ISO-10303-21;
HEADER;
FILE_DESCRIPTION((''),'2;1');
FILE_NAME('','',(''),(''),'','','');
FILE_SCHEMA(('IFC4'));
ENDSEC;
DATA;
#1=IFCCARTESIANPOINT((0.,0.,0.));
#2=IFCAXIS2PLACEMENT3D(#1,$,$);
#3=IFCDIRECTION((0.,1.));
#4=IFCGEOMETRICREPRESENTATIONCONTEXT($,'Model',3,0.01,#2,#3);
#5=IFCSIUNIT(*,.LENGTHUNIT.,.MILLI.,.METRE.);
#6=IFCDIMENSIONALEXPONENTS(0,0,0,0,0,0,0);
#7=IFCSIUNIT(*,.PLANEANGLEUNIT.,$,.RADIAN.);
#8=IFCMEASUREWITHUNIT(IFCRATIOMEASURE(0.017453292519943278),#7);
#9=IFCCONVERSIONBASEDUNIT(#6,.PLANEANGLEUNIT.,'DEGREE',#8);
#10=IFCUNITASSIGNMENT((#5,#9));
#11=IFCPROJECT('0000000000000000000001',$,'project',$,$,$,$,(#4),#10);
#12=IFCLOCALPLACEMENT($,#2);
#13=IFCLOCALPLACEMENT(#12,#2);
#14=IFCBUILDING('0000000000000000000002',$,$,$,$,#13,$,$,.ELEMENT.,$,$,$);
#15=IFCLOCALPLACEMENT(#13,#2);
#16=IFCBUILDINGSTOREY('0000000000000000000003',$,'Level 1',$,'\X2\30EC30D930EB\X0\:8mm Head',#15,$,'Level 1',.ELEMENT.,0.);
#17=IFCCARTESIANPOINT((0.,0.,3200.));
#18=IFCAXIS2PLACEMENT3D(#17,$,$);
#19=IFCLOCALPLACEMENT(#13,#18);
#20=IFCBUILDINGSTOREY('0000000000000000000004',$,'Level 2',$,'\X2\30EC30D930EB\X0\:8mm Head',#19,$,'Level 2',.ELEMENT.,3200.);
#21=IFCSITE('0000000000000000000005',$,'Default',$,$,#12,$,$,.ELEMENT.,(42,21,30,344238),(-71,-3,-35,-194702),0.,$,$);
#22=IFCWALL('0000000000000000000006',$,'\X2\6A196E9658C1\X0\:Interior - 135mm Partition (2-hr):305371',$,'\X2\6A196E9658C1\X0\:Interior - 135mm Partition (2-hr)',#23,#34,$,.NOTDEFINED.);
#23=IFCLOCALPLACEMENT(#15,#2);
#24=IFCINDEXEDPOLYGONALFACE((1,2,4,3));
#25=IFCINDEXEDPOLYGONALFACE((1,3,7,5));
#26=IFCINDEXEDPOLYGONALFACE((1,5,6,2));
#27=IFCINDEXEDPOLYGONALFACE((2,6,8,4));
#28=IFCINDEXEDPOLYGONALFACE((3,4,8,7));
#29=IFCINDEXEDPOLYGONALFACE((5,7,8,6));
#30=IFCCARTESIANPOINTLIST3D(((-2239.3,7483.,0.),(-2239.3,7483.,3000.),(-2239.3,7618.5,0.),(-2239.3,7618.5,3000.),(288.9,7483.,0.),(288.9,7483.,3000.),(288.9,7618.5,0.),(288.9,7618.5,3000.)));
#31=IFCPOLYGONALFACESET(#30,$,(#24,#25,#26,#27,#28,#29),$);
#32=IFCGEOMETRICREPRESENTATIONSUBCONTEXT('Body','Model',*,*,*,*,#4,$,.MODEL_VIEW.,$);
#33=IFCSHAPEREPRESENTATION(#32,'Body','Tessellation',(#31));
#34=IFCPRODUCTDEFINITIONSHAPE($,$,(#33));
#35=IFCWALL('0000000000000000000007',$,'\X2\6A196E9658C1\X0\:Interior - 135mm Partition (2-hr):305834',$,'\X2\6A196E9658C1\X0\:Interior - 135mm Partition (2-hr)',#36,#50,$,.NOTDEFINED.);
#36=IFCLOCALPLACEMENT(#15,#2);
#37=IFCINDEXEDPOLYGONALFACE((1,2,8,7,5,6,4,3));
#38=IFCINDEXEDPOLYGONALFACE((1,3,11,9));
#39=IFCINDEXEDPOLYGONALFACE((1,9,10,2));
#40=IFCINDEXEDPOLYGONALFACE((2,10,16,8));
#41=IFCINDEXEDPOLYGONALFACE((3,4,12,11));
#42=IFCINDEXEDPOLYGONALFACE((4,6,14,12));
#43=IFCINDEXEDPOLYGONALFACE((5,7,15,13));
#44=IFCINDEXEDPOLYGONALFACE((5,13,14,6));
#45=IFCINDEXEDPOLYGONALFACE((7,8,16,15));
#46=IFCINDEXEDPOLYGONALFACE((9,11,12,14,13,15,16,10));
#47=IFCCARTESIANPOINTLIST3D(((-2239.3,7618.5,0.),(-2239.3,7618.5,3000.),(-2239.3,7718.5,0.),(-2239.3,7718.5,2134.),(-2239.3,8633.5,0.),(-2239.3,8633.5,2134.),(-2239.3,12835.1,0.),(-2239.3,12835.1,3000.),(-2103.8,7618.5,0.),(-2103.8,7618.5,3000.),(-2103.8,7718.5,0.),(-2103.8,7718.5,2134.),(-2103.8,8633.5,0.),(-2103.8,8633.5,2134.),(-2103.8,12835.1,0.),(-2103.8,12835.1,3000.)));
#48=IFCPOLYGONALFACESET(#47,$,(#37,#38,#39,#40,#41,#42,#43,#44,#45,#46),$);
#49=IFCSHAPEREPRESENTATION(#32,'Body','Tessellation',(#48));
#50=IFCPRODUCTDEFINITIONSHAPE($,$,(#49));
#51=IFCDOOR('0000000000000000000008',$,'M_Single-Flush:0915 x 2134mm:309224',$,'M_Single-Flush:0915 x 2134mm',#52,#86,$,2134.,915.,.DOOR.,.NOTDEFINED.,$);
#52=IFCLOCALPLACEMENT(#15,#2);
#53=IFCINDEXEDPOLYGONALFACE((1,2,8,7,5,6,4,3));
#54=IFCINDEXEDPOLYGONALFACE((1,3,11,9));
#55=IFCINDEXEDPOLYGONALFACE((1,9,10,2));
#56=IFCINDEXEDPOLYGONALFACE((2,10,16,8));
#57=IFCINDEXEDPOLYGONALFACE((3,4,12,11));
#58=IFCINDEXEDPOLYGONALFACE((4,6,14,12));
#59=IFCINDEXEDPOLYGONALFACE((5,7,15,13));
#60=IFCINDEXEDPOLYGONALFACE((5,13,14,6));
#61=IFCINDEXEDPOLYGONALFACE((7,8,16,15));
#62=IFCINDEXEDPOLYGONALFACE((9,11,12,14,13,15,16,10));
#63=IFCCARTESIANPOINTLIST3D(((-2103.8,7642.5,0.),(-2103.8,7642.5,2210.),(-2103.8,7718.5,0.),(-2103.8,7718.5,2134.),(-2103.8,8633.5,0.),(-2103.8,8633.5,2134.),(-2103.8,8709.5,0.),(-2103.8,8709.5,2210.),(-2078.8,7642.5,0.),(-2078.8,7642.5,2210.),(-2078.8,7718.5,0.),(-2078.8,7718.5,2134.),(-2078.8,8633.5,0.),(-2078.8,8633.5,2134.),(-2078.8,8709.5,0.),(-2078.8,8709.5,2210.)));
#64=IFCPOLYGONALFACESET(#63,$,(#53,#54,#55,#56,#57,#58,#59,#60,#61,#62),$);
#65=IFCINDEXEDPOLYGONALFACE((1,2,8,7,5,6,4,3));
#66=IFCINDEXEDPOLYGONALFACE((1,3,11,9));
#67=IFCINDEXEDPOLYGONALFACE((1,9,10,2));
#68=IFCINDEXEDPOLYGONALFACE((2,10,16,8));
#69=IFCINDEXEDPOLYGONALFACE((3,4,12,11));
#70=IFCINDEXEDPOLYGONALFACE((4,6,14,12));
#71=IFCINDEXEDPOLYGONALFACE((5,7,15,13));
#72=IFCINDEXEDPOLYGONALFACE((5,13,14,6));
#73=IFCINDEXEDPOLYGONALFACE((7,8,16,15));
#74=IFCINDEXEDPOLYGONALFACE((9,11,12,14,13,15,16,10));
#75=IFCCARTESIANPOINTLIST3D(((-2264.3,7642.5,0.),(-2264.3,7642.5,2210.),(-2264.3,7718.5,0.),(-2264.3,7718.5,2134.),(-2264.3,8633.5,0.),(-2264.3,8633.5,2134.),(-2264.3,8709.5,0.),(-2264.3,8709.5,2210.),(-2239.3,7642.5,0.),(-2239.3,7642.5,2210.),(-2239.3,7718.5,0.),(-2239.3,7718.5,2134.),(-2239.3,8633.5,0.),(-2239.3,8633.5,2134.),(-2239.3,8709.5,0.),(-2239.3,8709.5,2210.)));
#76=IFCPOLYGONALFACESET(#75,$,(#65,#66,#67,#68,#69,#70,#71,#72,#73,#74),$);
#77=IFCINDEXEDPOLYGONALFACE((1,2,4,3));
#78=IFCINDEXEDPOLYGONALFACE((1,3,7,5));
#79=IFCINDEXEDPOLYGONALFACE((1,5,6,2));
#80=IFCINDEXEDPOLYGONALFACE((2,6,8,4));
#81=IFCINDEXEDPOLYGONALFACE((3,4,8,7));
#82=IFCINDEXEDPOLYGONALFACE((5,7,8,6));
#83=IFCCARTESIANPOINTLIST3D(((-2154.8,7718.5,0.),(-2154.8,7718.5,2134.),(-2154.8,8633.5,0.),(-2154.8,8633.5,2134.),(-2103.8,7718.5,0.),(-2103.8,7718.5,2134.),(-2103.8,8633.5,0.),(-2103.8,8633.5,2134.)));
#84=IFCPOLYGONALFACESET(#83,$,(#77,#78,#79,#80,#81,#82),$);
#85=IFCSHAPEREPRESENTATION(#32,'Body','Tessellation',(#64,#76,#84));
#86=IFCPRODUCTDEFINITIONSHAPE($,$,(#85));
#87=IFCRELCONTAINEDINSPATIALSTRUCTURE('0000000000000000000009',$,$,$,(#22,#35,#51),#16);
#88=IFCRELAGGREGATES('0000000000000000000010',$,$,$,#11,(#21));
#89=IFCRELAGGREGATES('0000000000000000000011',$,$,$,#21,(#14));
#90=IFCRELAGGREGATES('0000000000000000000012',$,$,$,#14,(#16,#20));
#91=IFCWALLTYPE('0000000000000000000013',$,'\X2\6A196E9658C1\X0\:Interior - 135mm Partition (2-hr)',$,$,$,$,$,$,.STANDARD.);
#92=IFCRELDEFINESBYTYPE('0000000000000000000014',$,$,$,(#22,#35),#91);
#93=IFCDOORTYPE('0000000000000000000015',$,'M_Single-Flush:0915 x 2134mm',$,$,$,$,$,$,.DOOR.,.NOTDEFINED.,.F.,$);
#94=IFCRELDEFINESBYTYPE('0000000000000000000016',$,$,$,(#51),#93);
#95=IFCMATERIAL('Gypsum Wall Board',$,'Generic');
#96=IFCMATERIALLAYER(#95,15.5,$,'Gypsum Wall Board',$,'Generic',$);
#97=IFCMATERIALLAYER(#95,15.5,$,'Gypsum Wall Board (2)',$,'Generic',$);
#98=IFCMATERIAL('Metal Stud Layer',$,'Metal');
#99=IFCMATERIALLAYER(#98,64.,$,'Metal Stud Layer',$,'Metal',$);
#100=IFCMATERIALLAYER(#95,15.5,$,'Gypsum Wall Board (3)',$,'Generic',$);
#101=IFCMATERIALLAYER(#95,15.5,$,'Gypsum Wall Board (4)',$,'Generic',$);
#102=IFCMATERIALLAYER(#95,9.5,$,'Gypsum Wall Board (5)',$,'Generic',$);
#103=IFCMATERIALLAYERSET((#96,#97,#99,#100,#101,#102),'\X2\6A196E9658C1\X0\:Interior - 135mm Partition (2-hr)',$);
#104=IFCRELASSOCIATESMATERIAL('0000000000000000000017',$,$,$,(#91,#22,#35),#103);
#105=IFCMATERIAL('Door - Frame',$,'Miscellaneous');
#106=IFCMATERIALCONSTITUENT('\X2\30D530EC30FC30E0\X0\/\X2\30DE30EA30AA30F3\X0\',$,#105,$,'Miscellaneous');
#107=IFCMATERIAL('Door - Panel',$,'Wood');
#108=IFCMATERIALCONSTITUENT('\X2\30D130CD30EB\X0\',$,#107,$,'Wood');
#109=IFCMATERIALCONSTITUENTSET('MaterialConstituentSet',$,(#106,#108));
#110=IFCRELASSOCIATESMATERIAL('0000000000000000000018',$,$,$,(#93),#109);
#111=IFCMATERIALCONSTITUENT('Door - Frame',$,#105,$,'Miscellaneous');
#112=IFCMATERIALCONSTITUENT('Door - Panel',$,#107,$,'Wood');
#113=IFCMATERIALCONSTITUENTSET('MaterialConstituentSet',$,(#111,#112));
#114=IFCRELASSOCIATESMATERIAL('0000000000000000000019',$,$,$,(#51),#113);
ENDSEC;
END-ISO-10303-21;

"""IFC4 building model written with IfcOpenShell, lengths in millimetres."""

from ifc_helpers import new_model, entity, si_unit, converted_unit, direction, frame, frame_2d, origin, place, context, subcontext, project, spatial, polyline, rectangle, outline, extrude, clip, bounded_halfspace, source, transform, mapped, material, layer, layer_set, layer_usage, constituent, constituent_set, type_object, type_shapes, element, fill, save


model = new_model("IFC4")

# Units and contexts
model_context = context("Model", 3, precision=0.01, world=origin(), true_north=direction((0.0, 1.0)))
body_context = subcontext(model_context, "Body", "Model", "MODEL_VIEW")
ifc_project = project(units=[si_unit("LENGTHUNIT", "METRE", prefix="MILLI"), converted_unit("PLANEANGLEUNIT", "DEGREE", entity("IfcRatioMeasure", 0.017453292519943278), si_unit("PLANEANGLEUNIT", "RADIAN"), dimensions=[0, 0, 0, 0, 0, 0, 0])], contexts=[model_context])

# Site, building, storey
site_placement = place(None, origin())
site = spatial("IfcSite", under=ifc_project, at=site_placement, Name="Default", CompositionType="ELEMENT", RefLatitude=(42, 21, 30, 344238), RefLongitude=(-71, -3, -35, -194702), RefElevation=0.0)
building_placement = place(site_placement, origin())
building = spatial("IfcBuilding", under=site, at=building_placement, CompositionType="ELEMENT")
storey_1_placement = place(building_placement, origin())
storey_1 = spatial("IfcBuildingStorey", under=building, at=storey_1_placement, Name="Level 1", ObjectType="レベル:8mm Head", LongName="Level 1", CompositionType="ELEMENT", Elevation=0.0)

# Shared definitions
storey_2_placement = place(building_placement, frame((0.0, 0.0, 3200.0)))
storey_2 = spatial("IfcBuildingStorey", under=building, at=storey_2_placement, Name="Level 2", ObjectType="レベル:8mm Head", LongName="Level 2", CompositionType="ELEMENT", Elevation=3200.0)

# Wall
ifc_material_1 = material(Name="Gypsum Wall Board", Category="Generic")
ifc_layer_1 = layer(ifc_material_1, 15.5, Name="Gypsum Wall Board", Category="Generic")
ifc_layer_2 = layer(ifc_material_1, 15.5, Name="Gypsum Wall Board (2)", Category="Generic")
ifc_material_2 = material(Name="Metal Stud Layer", Category="Metal")
ifc_layer_3 = layer(ifc_material_2, 64.0, Name="Metal Stud Layer", Category="Metal")
ifc_layer_4 = layer(ifc_material_1, 15.5, Name="Gypsum Wall Board (3)", Category="Generic")
ifc_layer_5 = layer(ifc_material_1, 15.5, Name="Gypsum Wall Board (4)", Category="Generic")
ifc_layer_6 = layer(ifc_material_1, 9.5, Name="Gypsum Wall Board (5)", Category="Generic")
ifc_layer_set_1 = layer_set([ifc_layer_1, ifc_layer_2, ifc_layer_3, ifc_layer_4, ifc_layer_5, ifc_layer_6], Name="標準壁:Interior - 135mm Partition (2-hr)")
ifc_layer_usage_1 = layer_usage(ifc_layer_set_1, "AXIS2", "NEGATIVE", 67.8)
wall_type_1 = type_object("IfcWallType", Name="標準壁:Interior - 135mm Partition (2-hr)", PredefinedType="STANDARD", material=ifc_layer_set_1)
wall_1_placement = place(storey_1_placement, frame((288.9, 7550.8, 0.0), z_axis=(0.0, 0.0, 1.0), x_axis=(-1.0, 0.0, 0.0)))
element("IfcWall", 1, at=wall_1_placement, inside=storey_1, type_object=wall_type_1, material=ifc_layer_usage_1, Name="標準壁:Interior - 135mm Partition (2-hr):305371", ObjectType="標準壁:Interior - 135mm Partition (2-hr)", PredefinedType="NOTDEFINED", context=body_context, shape_type="Clipping", body=[
    clip(extrude(rectangle(XDim=2528.2, YDim=135.5, at=frame_2d((1264.1, 0.0), x_axis=(-1.0, 0.0))), origin(), (0.0, 0.0, 1.0), 3000.0), bounded_halfspace(frame((0.0, -67.7, 3000.0), z_axis=(0.0, 0.0, -1.0), x_axis=(-1.0, 0.0, 0.0)), True, frame((0.0, -67.7, 3000.0)), polyline([(0.0, 0.0), (2392.7, 0.0), (2528.2, 0.0), (2528.2, 135.5), (0.0, 135.5), (0.0, 0.0)]))),
])

# Wall, opening, door
ifc_layer_usage_2 = layer_usage(ifc_layer_set_1, "AXIS2", "NEGATIVE", 67.8)
wall_2_placement = place(storey_1_placement, frame((-2171.5, 12835.1, 0.0), z_axis=(0.0, 0.0, 1.0), x_axis=(0.0, -1.0, 0.0)))
wall_2 = element("IfcWall", 2, at=wall_2_placement, inside=storey_1, type_object=wall_type_1, material=ifc_layer_usage_2, Name="標準壁:Interior - 135mm Partition (2-hr):305834", ObjectType="標準壁:Interior - 135mm Partition (2-hr)", PredefinedType="NOTDEFINED", context=body_context, shape_type="Clipping", body=[
    clip(extrude(rectangle(XDim=5216.6, YDim=135.5, at=frame_2d((2608.3, 0.0), x_axis=(-1.0, 0.0))), origin(), (0.0, 0.0, 1.0), 3000.0), bounded_halfspace(frame((0.0, -67.8, 3000.0), z_axis=(0.0, 0.0, -1.0), x_axis=(0.0, 1.0, 0.0)), True, frame((0.0, -67.8, 3000.0)), polyline([(0.0, 0.0), (5216.6, 0.0), (5216.6, 135.5), (0.0, 135.5), (0.0, 0.0)]))),
])
opening_1_placement = place(wall_2_placement, frame((4201.6, -67.8, 0.0)))
opening_1 = element("IfcOpeningElement", 3, at=opening_1_placement, cuts=wall_2, PredefinedType="OPENING", context=body_context, shape_type="SweptSolid", body=[
    extrude(rectangle(XDim=915.0, YDim=2134.0, at=frame_2d((1067.0, 457.5), x_axis=(0.0, 1.0))), frame((0.0, 0.0, 0.0), z_axis=(0.0, 1.0, 0.0), x_axis=(0.0, 0.0, 1.0)), (0.0, 0.0, 1.0), 135.5),
])
ifc_material_3 = material(Name="Door - Frame", Category="Miscellaneous")
ifc_constituent_1 = constituent(ifc_material_3, Name="Door - Frame", Category="Miscellaneous")
ifc_material_4 = material(Name="Door - Panel", Category="Wood")
ifc_constituent_2 = constituent(ifc_material_4, Name="Door - Panel", Category="Wood")
ifc_constituent_set_1 = constituent_set(constituents=[ifc_constituent_1, ifc_constituent_2], Name="MaterialConstituentSet")
ifc_constituent_3 = constituent(ifc_material_3, Name="フレーム/マリオン", Category="Miscellaneous")
ifc_constituent_4 = constituent(ifc_material_4, Name="パネル", Category="Wood")
ifc_constituent_set_2 = constituent_set(constituents=[ifc_constituent_3, ifc_constituent_4], Name="MaterialConstituentSet")
door_type = type_object("IfcDoorType", Name="M_Single-Flush:0915 x 2134mm", OperationType="NOTDEFINED", ParameterTakesPrecedence=False, PredefinedType="DOOR", material=ifc_constituent_set_2)
shared_shape_1 = source(origin(), body_context, "Body", "SweptSolid", [
    extrude(outline(polyline([(-533.5, -1124.0), (533.5, -1124.0), (533.5, 1086.0), (457.5, 1086.0), (457.5, -1048.0), (-457.5, -1048.0), (-457.5, 1086.0), (-533.5, 1086.0), (-533.5, -1124.0)])), frame((457.5, 135.5, 1086.0), z_axis=(0.0, 1.0, 0.0), x_axis=(1.0, 0.0, 0.0)), (0.0, 0.0, 1.0), 25.0),
    extrude(outline(polyline([(-1124.0, -533.5), (1086.0, -533.5), (1086.0, -457.5), (-1048.0, -457.5), (-1048.0, 457.5), (1086.0, 457.5), (1086.0, 533.5), (-1124.0, 533.5), (-1124.0, -533.5)])), frame((457.5, -25.0, 1086.0), z_axis=(0.0, 1.0, 0.0), x_axis=(0.0, 0.0, -1.0)), (0.0, 0.0, 1.0), 25.0),
    extrude(rectangle(XDim=51.0, YDim=915.0, at=frame_2d((0.0, 0.0), x_axis=(1.0, 0.0))), frame((457.5, 110.0, 0.0), z_axis=(0.0, 0.0, 1.0), x_axis=(0.0, 1.0, 0.0)), (0.0, 0.0, 1.0), 2134.0),
])
type_shapes(door_type, [shared_shape_1])
door_placement = place(opening_1_placement, origin())
door = element("IfcDoor", 4, at=door_placement, inside=storey_1, type_object=door_type, material=ifc_constituent_set_1, Name="M_Single-Flush:0915 x 2134mm:309224", ObjectType="M_Single-Flush:0915 x 2134mm", OperationType="NOTDEFINED", OverallHeight=2134.0, OverallWidth=915.0, PredefinedType="DOOR", context=body_context, shape_type="MappedRepresentation", body=[
    mapped(shared_shape_1, transform((0.0, 0.0, 0.0), scale=1.0)),
])
fill(opening_1, door)

save(model, "model.ifc")
